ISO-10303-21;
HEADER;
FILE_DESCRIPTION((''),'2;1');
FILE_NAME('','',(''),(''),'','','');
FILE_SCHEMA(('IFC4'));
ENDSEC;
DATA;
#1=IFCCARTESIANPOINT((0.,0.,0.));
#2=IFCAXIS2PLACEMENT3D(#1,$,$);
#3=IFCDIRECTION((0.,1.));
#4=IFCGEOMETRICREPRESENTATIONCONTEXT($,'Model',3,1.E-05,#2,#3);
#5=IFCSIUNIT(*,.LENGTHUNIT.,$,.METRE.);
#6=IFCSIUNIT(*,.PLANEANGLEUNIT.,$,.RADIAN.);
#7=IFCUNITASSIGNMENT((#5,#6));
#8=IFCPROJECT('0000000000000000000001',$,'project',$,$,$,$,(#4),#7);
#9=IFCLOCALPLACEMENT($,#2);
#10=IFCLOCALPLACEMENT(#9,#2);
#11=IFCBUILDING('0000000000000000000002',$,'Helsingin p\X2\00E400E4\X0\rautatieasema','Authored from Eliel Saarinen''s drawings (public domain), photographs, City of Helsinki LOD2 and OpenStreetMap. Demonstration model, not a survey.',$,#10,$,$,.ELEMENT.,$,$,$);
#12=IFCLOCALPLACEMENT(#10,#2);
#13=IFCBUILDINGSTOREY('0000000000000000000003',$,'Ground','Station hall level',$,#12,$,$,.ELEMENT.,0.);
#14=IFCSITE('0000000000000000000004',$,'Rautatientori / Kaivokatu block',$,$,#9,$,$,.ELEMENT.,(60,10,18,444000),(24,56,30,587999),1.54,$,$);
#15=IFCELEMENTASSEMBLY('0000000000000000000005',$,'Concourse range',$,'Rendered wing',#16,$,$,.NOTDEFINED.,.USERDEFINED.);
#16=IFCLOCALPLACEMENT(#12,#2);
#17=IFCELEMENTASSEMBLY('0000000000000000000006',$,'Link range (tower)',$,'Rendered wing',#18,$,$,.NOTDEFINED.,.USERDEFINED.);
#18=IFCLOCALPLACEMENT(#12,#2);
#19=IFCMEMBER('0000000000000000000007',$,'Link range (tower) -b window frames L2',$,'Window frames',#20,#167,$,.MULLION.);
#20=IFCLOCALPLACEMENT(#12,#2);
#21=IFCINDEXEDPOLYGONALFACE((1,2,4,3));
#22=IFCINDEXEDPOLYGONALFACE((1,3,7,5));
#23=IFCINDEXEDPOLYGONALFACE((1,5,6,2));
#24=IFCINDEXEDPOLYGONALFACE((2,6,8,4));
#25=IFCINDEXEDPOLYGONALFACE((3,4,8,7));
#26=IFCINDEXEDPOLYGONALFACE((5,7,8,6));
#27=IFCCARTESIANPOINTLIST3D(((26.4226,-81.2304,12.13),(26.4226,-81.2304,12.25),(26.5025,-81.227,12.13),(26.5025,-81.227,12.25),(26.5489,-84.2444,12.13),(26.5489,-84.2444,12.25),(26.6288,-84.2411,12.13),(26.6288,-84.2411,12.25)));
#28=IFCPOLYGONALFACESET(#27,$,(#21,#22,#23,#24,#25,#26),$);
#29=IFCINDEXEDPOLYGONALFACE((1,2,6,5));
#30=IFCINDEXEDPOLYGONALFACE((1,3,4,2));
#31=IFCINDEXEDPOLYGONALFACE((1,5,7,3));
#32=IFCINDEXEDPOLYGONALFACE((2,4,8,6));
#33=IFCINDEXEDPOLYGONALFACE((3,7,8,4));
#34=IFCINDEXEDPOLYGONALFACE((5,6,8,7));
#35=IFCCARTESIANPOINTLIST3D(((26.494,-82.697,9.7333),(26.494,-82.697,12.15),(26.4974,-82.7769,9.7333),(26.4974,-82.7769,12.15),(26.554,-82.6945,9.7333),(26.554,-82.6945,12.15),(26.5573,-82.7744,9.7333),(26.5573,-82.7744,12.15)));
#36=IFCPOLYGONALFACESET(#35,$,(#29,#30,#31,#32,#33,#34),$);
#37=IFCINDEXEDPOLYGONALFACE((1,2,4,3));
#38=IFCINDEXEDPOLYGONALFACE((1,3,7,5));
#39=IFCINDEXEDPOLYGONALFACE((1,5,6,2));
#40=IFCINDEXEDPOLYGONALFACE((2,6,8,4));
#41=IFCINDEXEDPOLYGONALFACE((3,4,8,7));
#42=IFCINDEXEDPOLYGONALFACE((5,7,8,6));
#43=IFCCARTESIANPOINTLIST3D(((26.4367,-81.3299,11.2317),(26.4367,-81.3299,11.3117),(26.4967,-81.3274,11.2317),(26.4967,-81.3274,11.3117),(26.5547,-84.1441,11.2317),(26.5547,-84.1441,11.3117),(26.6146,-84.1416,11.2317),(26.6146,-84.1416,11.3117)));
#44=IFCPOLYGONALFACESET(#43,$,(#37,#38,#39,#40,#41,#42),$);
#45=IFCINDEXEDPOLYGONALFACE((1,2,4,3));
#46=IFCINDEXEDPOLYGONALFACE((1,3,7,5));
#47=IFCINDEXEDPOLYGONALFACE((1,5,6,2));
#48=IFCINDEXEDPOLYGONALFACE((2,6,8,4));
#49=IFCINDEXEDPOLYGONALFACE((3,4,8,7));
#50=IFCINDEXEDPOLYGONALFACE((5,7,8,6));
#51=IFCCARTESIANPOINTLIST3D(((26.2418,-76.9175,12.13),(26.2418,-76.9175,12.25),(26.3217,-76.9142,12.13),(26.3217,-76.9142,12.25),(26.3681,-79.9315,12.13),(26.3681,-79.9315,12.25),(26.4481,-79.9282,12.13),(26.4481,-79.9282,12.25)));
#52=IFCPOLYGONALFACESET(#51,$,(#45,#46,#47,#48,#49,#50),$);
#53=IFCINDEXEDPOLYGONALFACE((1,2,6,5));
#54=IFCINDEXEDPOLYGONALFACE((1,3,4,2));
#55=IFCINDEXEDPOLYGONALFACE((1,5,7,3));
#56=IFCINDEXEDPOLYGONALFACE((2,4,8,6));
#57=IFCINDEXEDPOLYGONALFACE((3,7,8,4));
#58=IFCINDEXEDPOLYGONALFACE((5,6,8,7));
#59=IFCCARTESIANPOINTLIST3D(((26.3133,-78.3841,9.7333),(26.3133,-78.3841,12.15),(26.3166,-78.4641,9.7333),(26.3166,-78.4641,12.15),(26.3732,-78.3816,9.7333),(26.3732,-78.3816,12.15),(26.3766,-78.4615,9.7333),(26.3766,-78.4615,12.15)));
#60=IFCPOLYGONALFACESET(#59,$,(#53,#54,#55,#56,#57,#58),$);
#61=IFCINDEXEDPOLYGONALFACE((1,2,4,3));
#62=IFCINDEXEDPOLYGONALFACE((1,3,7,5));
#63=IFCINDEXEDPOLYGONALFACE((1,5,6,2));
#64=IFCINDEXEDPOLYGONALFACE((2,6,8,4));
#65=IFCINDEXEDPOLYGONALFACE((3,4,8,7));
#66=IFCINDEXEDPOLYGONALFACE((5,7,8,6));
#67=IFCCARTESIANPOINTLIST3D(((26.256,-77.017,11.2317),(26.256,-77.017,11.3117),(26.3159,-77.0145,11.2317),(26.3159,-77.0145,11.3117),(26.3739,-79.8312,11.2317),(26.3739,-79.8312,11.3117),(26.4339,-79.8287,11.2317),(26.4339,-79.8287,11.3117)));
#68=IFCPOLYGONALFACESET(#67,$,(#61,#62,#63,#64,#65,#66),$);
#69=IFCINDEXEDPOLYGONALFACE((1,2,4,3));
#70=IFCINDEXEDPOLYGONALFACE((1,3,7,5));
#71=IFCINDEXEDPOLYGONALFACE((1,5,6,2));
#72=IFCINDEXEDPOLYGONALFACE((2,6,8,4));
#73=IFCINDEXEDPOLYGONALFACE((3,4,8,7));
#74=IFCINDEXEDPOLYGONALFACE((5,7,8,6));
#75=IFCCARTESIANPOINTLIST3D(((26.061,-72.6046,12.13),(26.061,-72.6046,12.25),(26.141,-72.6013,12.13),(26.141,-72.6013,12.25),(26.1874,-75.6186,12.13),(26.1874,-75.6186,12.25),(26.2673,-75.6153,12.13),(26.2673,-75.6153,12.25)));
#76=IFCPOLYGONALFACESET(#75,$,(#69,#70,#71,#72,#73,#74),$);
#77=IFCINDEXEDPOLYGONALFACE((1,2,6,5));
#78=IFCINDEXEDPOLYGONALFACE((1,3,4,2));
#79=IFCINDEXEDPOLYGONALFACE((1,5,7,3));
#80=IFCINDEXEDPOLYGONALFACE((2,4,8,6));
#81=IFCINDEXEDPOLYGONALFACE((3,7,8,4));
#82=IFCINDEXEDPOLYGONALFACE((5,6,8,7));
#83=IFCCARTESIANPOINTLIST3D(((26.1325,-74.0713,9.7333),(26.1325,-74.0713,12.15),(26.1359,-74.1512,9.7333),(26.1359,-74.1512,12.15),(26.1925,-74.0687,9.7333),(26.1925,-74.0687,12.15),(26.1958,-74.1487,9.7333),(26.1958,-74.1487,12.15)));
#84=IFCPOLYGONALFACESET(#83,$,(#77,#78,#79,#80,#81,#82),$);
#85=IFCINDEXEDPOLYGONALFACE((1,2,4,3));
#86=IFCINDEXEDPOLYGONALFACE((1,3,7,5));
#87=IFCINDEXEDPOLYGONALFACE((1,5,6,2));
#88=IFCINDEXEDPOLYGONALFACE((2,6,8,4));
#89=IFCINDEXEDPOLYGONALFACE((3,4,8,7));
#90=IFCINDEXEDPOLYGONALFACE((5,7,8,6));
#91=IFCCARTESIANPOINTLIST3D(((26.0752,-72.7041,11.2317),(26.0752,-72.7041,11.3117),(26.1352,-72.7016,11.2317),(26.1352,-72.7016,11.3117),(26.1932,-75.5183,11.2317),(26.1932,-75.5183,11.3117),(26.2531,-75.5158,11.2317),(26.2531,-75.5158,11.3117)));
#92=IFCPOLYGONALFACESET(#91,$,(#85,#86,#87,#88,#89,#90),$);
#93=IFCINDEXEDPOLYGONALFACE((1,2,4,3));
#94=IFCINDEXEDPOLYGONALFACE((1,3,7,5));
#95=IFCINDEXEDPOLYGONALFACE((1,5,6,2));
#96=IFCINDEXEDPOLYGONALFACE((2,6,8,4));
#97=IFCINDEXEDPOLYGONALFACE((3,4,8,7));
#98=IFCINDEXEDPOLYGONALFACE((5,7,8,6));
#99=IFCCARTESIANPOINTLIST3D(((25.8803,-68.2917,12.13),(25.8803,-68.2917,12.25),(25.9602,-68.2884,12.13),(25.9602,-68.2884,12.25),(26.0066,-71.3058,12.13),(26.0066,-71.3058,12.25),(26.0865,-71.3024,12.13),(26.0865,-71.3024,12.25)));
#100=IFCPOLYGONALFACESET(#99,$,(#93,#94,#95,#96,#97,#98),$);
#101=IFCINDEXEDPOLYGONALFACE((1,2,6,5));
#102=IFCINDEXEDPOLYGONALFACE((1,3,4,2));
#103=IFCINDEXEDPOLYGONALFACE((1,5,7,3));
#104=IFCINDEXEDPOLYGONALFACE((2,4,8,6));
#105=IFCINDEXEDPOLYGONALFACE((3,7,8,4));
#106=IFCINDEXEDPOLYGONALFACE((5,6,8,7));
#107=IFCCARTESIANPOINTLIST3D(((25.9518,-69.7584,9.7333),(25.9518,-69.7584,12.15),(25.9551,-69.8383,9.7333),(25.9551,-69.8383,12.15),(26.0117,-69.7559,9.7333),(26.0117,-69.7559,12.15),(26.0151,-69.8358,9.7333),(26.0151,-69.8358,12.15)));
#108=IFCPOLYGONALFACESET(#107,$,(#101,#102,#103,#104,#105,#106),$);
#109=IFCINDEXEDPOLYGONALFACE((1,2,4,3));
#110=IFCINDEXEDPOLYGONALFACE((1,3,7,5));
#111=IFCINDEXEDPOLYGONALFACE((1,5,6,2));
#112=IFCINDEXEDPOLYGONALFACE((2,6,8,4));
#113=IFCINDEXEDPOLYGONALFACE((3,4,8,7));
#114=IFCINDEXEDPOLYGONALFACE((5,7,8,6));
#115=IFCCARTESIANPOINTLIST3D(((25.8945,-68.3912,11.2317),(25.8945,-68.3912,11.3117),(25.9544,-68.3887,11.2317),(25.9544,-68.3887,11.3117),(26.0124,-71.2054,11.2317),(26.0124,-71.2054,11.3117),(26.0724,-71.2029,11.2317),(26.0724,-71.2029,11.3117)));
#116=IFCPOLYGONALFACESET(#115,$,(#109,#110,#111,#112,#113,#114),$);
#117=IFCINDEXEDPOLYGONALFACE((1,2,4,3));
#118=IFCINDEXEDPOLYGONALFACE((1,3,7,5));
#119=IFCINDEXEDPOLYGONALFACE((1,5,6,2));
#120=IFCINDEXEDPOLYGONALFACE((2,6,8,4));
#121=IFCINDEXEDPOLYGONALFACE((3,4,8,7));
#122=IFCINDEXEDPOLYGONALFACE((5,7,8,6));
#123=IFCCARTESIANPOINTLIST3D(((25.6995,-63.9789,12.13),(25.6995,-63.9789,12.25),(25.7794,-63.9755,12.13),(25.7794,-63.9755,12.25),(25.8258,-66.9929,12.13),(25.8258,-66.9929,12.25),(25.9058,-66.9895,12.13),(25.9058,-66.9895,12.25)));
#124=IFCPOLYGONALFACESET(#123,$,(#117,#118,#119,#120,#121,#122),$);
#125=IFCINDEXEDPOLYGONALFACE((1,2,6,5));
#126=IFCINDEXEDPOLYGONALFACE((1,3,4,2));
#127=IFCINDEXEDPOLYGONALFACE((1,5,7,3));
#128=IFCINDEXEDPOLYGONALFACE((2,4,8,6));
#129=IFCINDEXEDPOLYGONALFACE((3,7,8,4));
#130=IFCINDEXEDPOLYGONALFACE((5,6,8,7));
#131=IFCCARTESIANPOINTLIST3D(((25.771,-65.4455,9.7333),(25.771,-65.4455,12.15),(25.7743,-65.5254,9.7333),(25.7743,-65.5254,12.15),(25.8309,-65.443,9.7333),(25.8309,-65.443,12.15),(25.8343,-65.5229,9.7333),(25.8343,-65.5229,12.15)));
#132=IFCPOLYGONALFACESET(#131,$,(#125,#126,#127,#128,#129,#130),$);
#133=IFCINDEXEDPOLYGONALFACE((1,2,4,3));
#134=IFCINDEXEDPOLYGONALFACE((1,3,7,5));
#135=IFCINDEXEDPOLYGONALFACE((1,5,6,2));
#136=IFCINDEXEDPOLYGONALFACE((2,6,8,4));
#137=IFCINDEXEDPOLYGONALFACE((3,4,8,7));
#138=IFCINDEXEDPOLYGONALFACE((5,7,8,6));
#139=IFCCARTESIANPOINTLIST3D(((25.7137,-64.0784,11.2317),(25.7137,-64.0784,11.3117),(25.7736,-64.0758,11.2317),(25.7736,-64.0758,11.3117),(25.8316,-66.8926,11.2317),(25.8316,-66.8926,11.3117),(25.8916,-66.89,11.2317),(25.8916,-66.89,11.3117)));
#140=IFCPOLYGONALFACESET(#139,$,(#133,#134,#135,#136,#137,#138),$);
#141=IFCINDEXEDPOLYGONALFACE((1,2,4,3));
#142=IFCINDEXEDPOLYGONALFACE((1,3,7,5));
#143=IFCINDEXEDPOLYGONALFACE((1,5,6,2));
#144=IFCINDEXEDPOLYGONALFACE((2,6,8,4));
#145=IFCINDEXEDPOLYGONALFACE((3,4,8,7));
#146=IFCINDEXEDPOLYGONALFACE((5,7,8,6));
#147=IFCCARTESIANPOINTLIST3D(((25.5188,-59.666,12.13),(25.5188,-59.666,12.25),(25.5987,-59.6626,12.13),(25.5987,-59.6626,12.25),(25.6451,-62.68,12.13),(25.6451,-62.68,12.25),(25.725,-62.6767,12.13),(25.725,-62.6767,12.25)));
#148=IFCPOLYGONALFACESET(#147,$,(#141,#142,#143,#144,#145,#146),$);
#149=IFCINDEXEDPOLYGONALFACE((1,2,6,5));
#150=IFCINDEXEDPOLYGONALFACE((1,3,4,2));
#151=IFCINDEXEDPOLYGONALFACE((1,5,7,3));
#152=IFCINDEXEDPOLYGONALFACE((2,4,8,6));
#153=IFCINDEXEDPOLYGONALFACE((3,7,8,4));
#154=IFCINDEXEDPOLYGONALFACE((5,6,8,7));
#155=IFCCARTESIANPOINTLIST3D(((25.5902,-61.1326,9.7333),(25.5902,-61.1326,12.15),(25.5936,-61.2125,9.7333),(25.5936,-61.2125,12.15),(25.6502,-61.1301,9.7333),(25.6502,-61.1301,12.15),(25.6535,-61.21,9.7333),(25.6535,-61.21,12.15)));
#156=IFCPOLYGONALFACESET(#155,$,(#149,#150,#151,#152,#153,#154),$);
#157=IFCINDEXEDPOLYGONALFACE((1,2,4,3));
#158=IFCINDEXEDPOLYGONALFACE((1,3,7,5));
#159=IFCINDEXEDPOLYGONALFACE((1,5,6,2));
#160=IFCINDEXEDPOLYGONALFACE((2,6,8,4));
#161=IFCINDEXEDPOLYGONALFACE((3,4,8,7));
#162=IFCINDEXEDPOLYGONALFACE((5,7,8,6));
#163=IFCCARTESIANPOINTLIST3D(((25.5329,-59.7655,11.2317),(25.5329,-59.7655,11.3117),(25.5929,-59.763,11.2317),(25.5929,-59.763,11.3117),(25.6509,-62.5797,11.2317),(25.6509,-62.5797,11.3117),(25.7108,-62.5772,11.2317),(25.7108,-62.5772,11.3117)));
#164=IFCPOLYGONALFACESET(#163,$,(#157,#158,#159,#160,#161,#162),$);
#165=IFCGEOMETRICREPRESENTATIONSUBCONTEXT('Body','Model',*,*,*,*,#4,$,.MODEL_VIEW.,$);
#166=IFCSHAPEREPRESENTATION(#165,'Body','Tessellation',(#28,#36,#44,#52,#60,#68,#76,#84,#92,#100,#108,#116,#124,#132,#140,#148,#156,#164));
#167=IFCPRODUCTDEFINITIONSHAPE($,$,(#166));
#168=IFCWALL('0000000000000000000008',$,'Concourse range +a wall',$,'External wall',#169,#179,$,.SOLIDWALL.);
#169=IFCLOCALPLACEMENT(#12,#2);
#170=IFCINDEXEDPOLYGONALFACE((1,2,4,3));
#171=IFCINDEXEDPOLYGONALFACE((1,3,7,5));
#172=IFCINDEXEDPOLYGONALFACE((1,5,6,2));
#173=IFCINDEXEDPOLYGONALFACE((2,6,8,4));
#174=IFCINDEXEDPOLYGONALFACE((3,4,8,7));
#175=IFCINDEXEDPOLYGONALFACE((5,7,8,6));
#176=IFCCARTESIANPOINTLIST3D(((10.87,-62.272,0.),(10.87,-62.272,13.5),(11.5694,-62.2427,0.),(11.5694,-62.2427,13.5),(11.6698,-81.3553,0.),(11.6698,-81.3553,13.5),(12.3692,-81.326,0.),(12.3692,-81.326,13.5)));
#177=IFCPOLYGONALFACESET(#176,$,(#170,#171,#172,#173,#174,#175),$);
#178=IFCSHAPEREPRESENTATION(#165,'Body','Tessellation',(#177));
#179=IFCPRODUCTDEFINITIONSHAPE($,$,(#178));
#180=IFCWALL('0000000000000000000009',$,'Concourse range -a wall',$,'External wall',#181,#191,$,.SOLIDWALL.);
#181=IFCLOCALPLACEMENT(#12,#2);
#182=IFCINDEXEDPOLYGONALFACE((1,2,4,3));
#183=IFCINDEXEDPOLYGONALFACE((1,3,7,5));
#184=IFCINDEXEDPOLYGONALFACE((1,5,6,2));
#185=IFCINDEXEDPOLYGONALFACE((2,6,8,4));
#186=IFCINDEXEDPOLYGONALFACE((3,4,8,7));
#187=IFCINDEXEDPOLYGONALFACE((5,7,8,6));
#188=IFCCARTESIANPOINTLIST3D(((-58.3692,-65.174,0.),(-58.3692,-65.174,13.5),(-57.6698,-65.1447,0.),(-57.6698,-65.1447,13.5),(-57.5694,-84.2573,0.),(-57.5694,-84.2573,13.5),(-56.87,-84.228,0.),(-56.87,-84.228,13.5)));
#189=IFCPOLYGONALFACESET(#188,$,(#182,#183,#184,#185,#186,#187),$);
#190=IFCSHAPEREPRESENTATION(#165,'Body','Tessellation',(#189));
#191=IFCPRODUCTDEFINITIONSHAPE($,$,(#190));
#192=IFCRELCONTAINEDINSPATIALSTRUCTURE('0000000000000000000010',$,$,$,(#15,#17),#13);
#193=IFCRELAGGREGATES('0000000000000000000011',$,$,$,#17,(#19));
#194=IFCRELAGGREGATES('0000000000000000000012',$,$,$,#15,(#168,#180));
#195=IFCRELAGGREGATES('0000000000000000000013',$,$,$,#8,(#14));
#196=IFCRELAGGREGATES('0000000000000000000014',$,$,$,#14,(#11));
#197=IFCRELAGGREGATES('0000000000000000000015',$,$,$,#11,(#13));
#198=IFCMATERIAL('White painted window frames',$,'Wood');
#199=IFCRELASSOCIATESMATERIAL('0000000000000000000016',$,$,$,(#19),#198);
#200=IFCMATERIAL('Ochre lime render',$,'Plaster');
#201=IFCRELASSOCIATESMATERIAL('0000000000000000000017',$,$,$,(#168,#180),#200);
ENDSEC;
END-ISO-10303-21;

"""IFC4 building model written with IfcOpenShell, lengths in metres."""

from ifc_helpers import new_model, si_unit, direction, frame, frame_2d, origin, place, context, subcontext, project, spatial, rectangle, extrude, material, element, aggregate, save


model = new_model("IFC4")

# Units and contexts
model_context = context("Model", 3, precision=1e-05, world=origin(), true_north=direction((0.0, 1.0)))
body_context = subcontext(model_context, "Body", "Model", "MODEL_VIEW")
ifc_project = project(units=[si_unit("LENGTHUNIT", "METRE"), si_unit("PLANEANGLEUNIT", "RADIAN")], contexts=[model_context])

# Site, building, storey
site_placement = place(None, origin())
site = spatial("IfcSite", under=ifc_project, at=site_placement, Name="Rautatientori / Kaivokatu block", CompositionType="ELEMENT", RefLatitude=(60, 10, 18, 444000), RefLongitude=(24, 56, 30, 587999), RefElevation=1.54)
building_placement = place(site_placement, origin())
building = spatial("IfcBuilding", under=site, at=building_placement, Name="Helsingin päärautatieasema", Description="Authored from Eliel Saarinen's drawings (public domain), photographs, City of Helsinki LOD2 and OpenStreetMap. Demonstration model, not a survey.", CompositionType="ELEMENT")
storey_placement = place(building_placement, origin())
storey = spatial("IfcBuildingStorey", under=building, at=storey_placement, Name="Ground", Description="Station hall level", CompositionType="ELEMENT", Elevation=0.0)

# Element assembly
assembly_1_placement = place(building_placement, origin())
assembly_1 = element("IfcElementAssembly", 1, at=assembly_1_placement, inside=storey, Name="Concourse range", ObjectType="Rendered wing", AssemblyPlace="NOTDEFINED", PredefinedType="USERDEFINED")
ifc_material_1 = material(Name="White painted window frames", Category="Wood")
ifc_material_2 = material(Name="Ochre lime render", Category="Plaster")

# Element assembly, member
assembly_2_placement = place(building_placement, origin())
assembly_2 = element("IfcElementAssembly", 2, at=assembly_2_placement, inside=storey, Name="Link range (tower)", ObjectType="Rendered wing", AssemblyPlace="NOTDEFINED", PredefinedType="USERDEFINED")
member_1_placement = place(building_placement, origin())
member_1 = element("IfcMember", 3, at=member_1_placement, material=ifc_material_1, Name="Link range (tower) -b window frames L2", ObjectType="Window frames", PredefinedType="MULLION", context=body_context, shape_type="SweptSolid", body=[
    extrude(rectangle(XDim=3.0167, YDim=0.08, at=frame_2d((0.0, 0.0), x_axis=(-0.041876, 0.999123))), frame((26.5257, -82.7357, 12.13)), (0.0, 0.0, 1.0), 0.12),
    extrude(rectangle(XDim=0.08, YDim=0.06, at=frame_2d((0.0, 0.0), x_axis=(-0.041876, 0.999123))), frame((26.5257, -82.7357, 9.7333)), (0.0, 0.0, 1.0), 2.4167),
    extrude(rectangle(XDim=2.8167, YDim=0.06, at=frame_2d((0.0, 0.0), x_axis=(-0.041876, 0.999123))), frame((26.5257, -82.7357, 11.2317)), (0.0, 0.0, 1.0), 0.08),
    extrude(rectangle(XDim=3.0167, YDim=0.08, at=frame_2d((0.0, 0.0), x_axis=(-0.041876, 0.999123))), frame((26.3449, -78.4228, 12.13)), (0.0, 0.0, 1.0), 0.12),
    extrude(rectangle(XDim=0.08, YDim=0.06, at=frame_2d((0.0, 0.0), x_axis=(-0.041876, 0.999123))), frame((26.3449, -78.4228, 9.7333)), (0.0, 0.0, 1.0), 2.4167),
    extrude(rectangle(XDim=2.8167, YDim=0.06, at=frame_2d((0.0, 0.0), x_axis=(-0.041876, 0.999123))), frame((26.3449, -78.4228, 11.2317)), (0.0, 0.0, 1.0), 0.08),
    extrude(rectangle(XDim=3.0167, YDim=0.08, at=frame_2d((0.0, 0.0), x_axis=(-0.041876, 0.999123))), frame((26.1642, -74.11, 12.13)), (0.0, 0.0, 1.0), 0.12),
    extrude(rectangle(XDim=0.08, YDim=0.06, at=frame_2d((0.0, 0.0), x_axis=(-0.041876, 0.999123))), frame((26.1642, -74.11, 9.7333)), (0.0, 0.0, 1.0), 2.4167),
    extrude(rectangle(XDim=2.8167, YDim=0.06, at=frame_2d((0.0, 0.0), x_axis=(-0.041876, 0.999123))), frame((26.1642, -74.11, 11.2317)), (0.0, 0.0, 1.0), 0.08),
    extrude(rectangle(XDim=3.0167, YDim=0.08, at=frame_2d((0.0, 0.0), x_axis=(-0.041876, 0.999123))), frame((25.9834, -69.7971, 12.13)), (0.0, 0.0, 1.0), 0.12),
    extrude(rectangle(XDim=0.08, YDim=0.06, at=frame_2d((0.0, 0.0), x_axis=(-0.041876, 0.999123))), frame((25.9834, -69.7971, 9.7333)), (0.0, 0.0, 1.0), 2.4167),
    extrude(rectangle(XDim=2.8167, YDim=0.06, at=frame_2d((0.0, 0.0), x_axis=(-0.041876, 0.999123))), frame((25.9834, -69.7971, 11.2317)), (0.0, 0.0, 1.0), 0.08),
    extrude(rectangle(XDim=3.0167, YDim=0.08, at=frame_2d((0.0, 0.0), x_axis=(-0.041876, 0.999123))), frame((25.8026, -65.4842, 12.13)), (0.0, 0.0, 1.0), 0.12),
    extrude(rectangle(XDim=0.08, YDim=0.06, at=frame_2d((0.0, 0.0), x_axis=(-0.041876, 0.999123))), frame((25.8026, -65.4842, 9.7333)), (0.0, 0.0, 1.0), 2.4167),
    extrude(rectangle(XDim=2.8167, YDim=0.06, at=frame_2d((0.0, 0.0), x_axis=(-0.041876, 0.999123))), frame((25.8026, -65.4842, 11.2317)), (0.0, 0.0, 1.0), 0.08),
    extrude(rectangle(XDim=3.0167, YDim=0.08, at=frame_2d((0.0, 0.0), x_axis=(-0.041876, 0.999123))), frame((25.6219, -61.1713, 12.13)), (0.0, 0.0, 1.0), 0.12),
    extrude(rectangle(XDim=0.08, YDim=0.06, at=frame_2d((0.0, 0.0), x_axis=(-0.041876, 0.999123))), frame((25.6219, -61.1713, 9.7333)), (0.0, 0.0, 1.0), 2.4167),
    extrude(rectangle(XDim=2.8167, YDim=0.06, at=frame_2d((0.0, 0.0), x_axis=(-0.041876, 0.999123))), frame((25.6219, -61.1713, 11.2317)), (0.0, 0.0, 1.0), 0.08),
])

# Walls
wall_1_placement = place(building_placement, origin())
wall_1 = element("IfcWall", 4, at=wall_1_placement, material=ifc_material_2, Name="Concourse range +a wall", ObjectType="External wall", PredefinedType="SOLIDWALL", context=body_context, shape_type="SweptSolid", body=[
    extrude(rectangle(XDim=19.1, YDim=0.7, at=frame_2d((0.0, 0.0), x_axis=(-0.041876, 0.999123))), frame((11.6196, -71.799, 0.0)), (0.0, 0.0, 1.0), 13.5),
])
wall_2_placement = place(building_placement, origin())
wall_2 = element("IfcWall", 5, at=wall_2_placement, material=ifc_material_2, Name="Concourse range -a wall", ObjectType="External wall", PredefinedType="SOLIDWALL", context=body_context, shape_type="SweptSolid", body=[
    extrude(rectangle(XDim=19.1, YDim=0.7, at=frame_2d((0.0, 0.0), x_axis=(0.041876, -0.999123))), frame((-57.6196, -74.701, 0.0)), (0.0, 0.0, 1.0), 13.5),
])

aggregate(assembly_2, [member_1])

aggregate(assembly_1, [wall_1, wall_2])

save(model, "model.ifc")
